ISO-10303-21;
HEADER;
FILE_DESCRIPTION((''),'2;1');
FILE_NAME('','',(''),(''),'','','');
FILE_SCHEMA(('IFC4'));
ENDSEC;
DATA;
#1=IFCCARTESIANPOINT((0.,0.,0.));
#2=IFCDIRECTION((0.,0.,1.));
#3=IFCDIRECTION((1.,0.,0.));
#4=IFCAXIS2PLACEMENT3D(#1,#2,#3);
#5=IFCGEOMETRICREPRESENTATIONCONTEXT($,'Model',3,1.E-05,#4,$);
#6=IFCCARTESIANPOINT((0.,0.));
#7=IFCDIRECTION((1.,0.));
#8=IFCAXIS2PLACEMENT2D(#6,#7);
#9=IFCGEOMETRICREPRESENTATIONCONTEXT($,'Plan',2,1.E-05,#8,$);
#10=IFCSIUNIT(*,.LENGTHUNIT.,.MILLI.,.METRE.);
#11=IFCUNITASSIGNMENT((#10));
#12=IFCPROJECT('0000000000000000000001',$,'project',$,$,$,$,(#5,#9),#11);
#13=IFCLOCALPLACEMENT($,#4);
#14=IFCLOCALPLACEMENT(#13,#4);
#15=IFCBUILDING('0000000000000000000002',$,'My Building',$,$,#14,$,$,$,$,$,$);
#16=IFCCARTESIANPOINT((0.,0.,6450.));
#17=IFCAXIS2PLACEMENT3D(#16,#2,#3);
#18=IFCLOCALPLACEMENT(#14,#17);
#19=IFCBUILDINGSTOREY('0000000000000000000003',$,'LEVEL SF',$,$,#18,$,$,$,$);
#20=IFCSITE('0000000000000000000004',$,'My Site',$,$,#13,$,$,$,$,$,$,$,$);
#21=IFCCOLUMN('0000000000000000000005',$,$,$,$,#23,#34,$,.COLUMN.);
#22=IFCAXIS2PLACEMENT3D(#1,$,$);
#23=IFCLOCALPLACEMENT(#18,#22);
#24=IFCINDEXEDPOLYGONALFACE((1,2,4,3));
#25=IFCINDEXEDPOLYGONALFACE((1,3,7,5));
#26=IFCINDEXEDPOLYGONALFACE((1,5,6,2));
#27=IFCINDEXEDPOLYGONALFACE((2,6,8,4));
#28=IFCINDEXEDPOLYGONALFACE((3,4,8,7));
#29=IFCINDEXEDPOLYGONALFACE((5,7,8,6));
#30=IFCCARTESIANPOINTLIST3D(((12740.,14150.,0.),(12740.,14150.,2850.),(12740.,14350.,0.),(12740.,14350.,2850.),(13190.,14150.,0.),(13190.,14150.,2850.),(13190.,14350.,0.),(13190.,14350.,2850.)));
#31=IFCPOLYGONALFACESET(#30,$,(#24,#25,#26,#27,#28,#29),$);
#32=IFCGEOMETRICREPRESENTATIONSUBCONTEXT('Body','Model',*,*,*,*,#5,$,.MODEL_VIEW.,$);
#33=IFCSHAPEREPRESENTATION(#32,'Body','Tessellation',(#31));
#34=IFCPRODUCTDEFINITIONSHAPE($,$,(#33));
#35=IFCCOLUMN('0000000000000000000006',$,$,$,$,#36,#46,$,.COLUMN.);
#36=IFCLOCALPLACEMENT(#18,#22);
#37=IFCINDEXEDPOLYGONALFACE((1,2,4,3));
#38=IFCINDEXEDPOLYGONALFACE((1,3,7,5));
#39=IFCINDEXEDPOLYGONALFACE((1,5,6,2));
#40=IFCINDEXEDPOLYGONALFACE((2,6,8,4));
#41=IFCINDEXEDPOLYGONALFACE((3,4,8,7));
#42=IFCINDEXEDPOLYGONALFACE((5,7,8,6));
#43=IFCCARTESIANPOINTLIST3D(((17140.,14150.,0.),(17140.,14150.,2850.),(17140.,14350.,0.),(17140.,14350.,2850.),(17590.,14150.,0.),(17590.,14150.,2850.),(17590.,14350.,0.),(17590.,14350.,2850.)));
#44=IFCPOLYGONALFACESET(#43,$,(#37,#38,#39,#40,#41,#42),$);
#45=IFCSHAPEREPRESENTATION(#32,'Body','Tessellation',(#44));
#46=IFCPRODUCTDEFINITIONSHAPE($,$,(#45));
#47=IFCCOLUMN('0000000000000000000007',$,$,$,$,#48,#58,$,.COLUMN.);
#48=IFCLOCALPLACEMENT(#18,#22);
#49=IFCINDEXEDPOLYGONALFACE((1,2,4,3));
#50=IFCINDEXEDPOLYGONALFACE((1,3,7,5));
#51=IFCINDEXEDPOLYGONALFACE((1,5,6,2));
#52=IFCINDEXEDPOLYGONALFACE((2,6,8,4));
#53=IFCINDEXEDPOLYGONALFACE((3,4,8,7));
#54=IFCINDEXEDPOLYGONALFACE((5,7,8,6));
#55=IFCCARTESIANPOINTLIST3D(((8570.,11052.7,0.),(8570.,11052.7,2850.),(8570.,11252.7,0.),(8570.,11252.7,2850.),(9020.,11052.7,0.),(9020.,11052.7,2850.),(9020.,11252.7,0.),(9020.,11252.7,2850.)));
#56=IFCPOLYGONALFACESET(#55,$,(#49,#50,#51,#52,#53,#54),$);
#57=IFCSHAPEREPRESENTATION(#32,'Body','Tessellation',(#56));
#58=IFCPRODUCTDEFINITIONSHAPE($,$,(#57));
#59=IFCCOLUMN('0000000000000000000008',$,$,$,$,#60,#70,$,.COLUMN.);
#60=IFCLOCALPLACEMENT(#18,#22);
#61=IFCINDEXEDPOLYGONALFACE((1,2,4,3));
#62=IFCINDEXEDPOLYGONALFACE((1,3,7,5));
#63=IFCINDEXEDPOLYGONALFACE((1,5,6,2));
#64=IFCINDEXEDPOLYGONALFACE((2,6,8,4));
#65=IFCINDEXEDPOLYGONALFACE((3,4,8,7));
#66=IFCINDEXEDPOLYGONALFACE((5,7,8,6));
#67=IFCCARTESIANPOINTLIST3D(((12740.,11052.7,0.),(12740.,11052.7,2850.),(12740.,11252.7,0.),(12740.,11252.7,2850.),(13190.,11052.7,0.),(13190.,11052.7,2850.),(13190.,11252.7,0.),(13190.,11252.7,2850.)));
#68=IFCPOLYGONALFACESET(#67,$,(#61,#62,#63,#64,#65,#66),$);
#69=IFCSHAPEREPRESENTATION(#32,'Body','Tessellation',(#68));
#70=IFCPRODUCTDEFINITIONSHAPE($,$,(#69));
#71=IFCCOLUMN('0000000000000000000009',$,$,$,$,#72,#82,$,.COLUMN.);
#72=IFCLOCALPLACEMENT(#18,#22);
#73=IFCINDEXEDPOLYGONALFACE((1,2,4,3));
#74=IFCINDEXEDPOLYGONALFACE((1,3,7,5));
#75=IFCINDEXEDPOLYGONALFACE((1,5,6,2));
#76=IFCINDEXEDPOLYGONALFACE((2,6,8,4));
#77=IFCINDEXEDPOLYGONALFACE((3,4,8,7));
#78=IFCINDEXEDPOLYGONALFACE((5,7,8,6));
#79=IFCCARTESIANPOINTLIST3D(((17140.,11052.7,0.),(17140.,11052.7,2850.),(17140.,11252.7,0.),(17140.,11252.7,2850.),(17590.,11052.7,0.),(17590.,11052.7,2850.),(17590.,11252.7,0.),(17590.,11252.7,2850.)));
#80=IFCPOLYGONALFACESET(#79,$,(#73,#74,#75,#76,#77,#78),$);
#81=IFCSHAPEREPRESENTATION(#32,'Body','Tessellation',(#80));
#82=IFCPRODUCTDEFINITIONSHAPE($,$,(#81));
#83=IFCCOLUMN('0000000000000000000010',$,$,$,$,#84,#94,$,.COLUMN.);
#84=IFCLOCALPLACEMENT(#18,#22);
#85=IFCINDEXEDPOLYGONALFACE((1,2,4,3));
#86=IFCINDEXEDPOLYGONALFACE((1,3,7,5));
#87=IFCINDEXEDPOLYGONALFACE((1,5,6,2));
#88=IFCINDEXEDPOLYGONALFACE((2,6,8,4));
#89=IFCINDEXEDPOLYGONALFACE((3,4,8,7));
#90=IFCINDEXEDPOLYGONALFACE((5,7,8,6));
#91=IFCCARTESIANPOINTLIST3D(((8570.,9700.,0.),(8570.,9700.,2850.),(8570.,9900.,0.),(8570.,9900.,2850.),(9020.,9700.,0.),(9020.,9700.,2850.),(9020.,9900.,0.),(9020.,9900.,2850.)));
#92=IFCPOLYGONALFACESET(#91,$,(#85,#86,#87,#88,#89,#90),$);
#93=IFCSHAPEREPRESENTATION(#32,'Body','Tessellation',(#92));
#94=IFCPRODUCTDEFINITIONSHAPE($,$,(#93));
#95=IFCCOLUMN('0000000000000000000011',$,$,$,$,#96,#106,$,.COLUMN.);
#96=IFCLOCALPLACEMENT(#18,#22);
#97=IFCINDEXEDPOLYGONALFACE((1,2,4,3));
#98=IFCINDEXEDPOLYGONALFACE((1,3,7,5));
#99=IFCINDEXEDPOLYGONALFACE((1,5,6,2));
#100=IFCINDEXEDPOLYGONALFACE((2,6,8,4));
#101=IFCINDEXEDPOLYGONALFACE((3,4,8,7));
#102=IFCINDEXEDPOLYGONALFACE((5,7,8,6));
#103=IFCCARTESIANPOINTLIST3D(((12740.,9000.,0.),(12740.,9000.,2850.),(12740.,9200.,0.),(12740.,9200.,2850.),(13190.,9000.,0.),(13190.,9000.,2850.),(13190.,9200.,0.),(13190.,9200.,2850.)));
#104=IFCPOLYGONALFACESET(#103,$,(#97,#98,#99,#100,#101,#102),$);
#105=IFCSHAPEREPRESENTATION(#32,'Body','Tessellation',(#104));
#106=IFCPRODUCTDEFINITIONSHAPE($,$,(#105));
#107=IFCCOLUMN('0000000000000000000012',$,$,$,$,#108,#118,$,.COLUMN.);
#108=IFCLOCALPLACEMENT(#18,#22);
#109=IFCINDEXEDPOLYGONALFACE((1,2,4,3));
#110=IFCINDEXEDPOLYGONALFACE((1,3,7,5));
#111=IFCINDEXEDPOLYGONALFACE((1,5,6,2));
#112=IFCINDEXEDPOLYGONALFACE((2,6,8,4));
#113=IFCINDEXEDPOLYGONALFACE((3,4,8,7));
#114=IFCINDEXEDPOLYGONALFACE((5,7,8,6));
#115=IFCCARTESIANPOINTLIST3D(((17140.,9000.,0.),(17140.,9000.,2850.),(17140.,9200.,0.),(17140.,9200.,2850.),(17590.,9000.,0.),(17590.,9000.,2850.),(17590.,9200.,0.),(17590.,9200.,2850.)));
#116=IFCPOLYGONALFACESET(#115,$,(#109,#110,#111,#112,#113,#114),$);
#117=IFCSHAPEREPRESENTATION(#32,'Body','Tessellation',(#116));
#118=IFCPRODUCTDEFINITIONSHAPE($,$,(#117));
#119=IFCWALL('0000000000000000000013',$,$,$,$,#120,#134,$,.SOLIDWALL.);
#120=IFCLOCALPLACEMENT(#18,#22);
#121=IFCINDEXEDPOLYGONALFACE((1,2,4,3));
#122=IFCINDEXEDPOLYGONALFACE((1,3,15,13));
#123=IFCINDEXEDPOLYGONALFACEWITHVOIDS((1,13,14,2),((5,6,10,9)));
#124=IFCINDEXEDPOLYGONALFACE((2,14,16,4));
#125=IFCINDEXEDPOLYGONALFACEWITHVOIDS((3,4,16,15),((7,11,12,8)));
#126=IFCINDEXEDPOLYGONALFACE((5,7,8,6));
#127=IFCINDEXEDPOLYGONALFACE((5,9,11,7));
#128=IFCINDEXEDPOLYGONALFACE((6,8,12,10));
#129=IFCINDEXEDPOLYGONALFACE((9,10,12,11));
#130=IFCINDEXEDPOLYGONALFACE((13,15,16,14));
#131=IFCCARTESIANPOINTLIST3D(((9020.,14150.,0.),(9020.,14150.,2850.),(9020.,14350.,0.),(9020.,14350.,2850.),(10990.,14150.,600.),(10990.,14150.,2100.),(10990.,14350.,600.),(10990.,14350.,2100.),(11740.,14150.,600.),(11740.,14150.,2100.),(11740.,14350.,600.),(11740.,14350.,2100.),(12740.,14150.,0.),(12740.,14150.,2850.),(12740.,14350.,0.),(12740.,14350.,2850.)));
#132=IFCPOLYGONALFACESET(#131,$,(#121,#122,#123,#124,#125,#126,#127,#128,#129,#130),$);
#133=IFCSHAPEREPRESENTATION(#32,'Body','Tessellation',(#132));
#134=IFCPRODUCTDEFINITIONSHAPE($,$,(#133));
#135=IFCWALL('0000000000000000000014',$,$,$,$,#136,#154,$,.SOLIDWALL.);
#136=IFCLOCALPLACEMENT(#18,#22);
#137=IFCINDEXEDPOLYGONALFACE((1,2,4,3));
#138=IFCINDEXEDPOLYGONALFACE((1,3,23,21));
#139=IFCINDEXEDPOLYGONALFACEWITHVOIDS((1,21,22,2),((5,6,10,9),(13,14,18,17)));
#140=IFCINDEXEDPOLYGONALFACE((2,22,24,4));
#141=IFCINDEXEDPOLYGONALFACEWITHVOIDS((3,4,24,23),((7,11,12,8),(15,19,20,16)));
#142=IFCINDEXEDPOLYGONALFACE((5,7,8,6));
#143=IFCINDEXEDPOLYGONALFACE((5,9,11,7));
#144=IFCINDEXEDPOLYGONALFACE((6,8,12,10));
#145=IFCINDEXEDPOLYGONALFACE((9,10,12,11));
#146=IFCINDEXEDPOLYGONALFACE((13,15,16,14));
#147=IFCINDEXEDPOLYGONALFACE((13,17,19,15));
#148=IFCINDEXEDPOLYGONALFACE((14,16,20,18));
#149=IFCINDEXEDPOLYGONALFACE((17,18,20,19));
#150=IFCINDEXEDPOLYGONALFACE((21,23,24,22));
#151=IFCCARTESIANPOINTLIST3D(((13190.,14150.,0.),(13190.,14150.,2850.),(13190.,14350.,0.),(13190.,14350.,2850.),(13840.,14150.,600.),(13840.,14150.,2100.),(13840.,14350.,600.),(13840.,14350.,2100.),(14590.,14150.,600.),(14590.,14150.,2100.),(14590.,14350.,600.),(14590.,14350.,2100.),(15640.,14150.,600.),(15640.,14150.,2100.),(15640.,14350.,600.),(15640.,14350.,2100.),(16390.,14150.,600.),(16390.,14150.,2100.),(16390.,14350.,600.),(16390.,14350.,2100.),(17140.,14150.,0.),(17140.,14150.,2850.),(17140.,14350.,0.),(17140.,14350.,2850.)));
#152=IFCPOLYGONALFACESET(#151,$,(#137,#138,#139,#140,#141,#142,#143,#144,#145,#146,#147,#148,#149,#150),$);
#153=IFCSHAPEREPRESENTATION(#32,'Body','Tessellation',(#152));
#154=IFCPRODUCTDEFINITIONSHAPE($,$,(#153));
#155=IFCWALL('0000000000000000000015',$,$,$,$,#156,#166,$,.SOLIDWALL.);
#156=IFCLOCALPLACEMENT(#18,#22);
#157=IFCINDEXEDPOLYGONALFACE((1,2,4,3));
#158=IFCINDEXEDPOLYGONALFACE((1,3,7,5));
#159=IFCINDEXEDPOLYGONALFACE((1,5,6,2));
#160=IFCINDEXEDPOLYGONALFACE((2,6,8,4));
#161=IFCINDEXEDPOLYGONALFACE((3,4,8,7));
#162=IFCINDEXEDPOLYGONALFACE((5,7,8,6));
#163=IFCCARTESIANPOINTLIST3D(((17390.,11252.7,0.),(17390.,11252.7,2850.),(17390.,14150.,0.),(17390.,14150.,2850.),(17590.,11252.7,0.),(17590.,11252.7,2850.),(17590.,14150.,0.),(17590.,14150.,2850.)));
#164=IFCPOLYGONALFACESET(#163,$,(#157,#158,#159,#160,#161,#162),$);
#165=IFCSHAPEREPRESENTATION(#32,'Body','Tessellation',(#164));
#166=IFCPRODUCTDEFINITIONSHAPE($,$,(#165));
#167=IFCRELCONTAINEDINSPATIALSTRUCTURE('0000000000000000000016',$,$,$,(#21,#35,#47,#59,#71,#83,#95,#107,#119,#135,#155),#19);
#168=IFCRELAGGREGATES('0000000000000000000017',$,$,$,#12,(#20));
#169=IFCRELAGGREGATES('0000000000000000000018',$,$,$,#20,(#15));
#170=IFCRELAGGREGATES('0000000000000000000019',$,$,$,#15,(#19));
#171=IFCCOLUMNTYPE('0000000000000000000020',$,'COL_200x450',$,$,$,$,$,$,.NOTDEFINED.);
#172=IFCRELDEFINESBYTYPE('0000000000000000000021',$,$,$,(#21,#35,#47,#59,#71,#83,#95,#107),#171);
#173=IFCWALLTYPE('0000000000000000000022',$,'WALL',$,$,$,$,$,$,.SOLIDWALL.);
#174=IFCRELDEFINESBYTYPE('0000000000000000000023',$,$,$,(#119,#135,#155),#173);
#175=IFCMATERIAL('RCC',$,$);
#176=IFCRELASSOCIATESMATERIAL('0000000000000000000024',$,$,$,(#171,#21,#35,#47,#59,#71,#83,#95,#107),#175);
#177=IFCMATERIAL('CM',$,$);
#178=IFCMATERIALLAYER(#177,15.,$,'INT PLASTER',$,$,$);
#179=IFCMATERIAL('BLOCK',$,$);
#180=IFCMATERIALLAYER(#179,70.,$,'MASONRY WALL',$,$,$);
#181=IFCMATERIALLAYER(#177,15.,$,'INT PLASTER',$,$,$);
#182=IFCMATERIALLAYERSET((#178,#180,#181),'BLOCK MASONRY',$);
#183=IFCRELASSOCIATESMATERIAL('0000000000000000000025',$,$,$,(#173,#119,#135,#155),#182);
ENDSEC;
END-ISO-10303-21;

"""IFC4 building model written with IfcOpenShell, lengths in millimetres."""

from ifc_helpers import new_model, si_unit, frame, origin_with_axes, origin_2d_with_axis, place, context, subcontext, project, spatial, indexed_curve, rectangle, outline, extrude, material, layer, layer_set, layer_usage, material_profile, profile_set, profile_usage, type_object, element, save


model = new_model("IFC4")

# Units and contexts
model_context = context("Model", 3, precision=1e-05, world=origin_with_axes())
plan_context = context("Plan", 2, precision=1e-05, world=origin_2d_with_axis())
body_context = subcontext(model_context, "Body", "Model", "MODEL_VIEW")
ifc_project = project(units=[si_unit("LENGTHUNIT", "METRE", prefix="MILLI")], contexts=[model_context, plan_context])

# Site, building, storey
site_placement = place(None, origin_with_axes())
site = spatial("IfcSite", under=ifc_project, at=site_placement, Name="My Site")
building_placement = place(site_placement, origin_with_axes())
building = spatial("IfcBuilding", under=site, at=building_placement, Name="My Building")
storey_placement = place(building_placement, frame((0.0, 0.0, 6450.0), z_axis=(0.0, 0.0, 1.0), x_axis=(1.0, 0.0, 0.0)))
storey = spatial("IfcBuildingStorey", under=building, at=storey_placement, Name="LEVEL SF")

# Columns
ifc_material_1 = material(Name="RCC")
ifc_material_profile = material_profile(ifc_material_1, rectangle(XDim=200.0, YDim=450.0))
ifc_profile_set = profile_set([ifc_material_profile], Name="COL_200x450")
ifc_profile_usage_1 = profile_usage(ifc_profile_set)
column_type = type_object("IfcColumnType", Name="COL_200x450", PredefinedType="NOTDEFINED", material=ifc_profile_set)
column_1_placement = place(storey_placement, frame((12965.0, 14250.0, 0.0), z_axis=(0.0, 0.0, 1.0), x_axis=(0.0, -1.0, 0.0)))
element("IfcColumn", 1, at=column_1_placement, inside=storey, type_object=column_type, material=ifc_profile_usage_1, PredefinedType="COLUMN", context=body_context, shape_type="SweptSolid", body=[
    extrude(rectangle(XDim=200.0, YDim=450.0), origin_with_axes(), (0.0, 0.0, 1.0), 2850.0),
])
ifc_profile_usage_2 = profile_usage(ifc_profile_set)
column_2_placement = place(storey_placement, frame((17365.0, 14250.0, 0.0), z_axis=(0.0, 0.0, 1.0), x_axis=(0.0, -1.0, 0.0)))
element("IfcColumn", 2, at=column_2_placement, inside=storey, type_object=column_type, material=ifc_profile_usage_2, PredefinedType="COLUMN", context=body_context, shape_type="SweptSolid", body=[
    extrude(rectangle(XDim=200.0, YDim=450.0), origin_with_axes(), (0.0, 0.0, 1.0), 2850.0),
])
ifc_profile_usage_3 = profile_usage(ifc_profile_set)
column_3_placement = place(storey_placement, frame((8795.0, 11152.7, 0.0), z_axis=(0.0, 0.0, 1.0), x_axis=(0.0, -1.0, 0.0)))
element("IfcColumn", 3, at=column_3_placement, inside=storey, type_object=column_type, material=ifc_profile_usage_3, PredefinedType="COLUMN", context=body_context, shape_type="SweptSolid", body=[
    extrude(rectangle(XDim=200.0, YDim=450.0), origin_with_axes(), (0.0, 0.0, 1.0), 2850.0),
])
ifc_profile_usage_4 = profile_usage(ifc_profile_set)
column_4_placement = place(storey_placement, frame((12965.0, 11152.7, 0.0), z_axis=(0.0, 0.0, 1.0), x_axis=(0.0, -1.0, 0.0)))
element("IfcColumn", 4, at=column_4_placement, inside=storey, type_object=column_type, material=ifc_profile_usage_4, PredefinedType="COLUMN", context=body_context, shape_type="SweptSolid", body=[
    extrude(rectangle(XDim=200.0, YDim=450.0), origin_with_axes(), (0.0, 0.0, 1.0), 2850.0),
])
ifc_profile_usage_5 = profile_usage(ifc_profile_set)
column_5_placement = place(storey_placement, frame((17365.0, 11152.7, 0.0), z_axis=(0.0, 0.0, 1.0), x_axis=(0.0, -1.0, 0.0)))
element("IfcColumn", 5, at=column_5_placement, inside=storey, type_object=column_type, material=ifc_profile_usage_5, PredefinedType="COLUMN", context=body_context, shape_type="SweptSolid", body=[
    extrude(rectangle(XDim=200.0, YDim=450.0), origin_with_axes(), (0.0, 0.0, 1.0), 2850.0),
])
ifc_profile_usage_6 = profile_usage(ifc_profile_set)
column_6_placement = place(storey_placement, frame((8795.0, 9800.0, 0.0), z_axis=(0.0, 0.0, 1.0), x_axis=(0.0, -1.0, 0.0)))
element("IfcColumn", 6, at=column_6_placement, inside=storey, type_object=column_type, material=ifc_profile_usage_6, PredefinedType="COLUMN", context=body_context, shape_type="SweptSolid", body=[
    extrude(rectangle(XDim=200.0, YDim=450.0), origin_with_axes(), (0.0, 0.0, 1.0), 2850.0),
])
ifc_profile_usage_7 = profile_usage(ifc_profile_set)
column_7_placement = place(storey_placement, frame((12965.0, 9100.0, 0.0), z_axis=(0.0, 0.0, 1.0), x_axis=(0.0, -1.0, 0.0)))
element("IfcColumn", 7, at=column_7_placement, inside=storey, type_object=column_type, material=ifc_profile_usage_7, PredefinedType="COLUMN", context=body_context, shape_type="SweptSolid", body=[
    extrude(rectangle(XDim=200.0, YDim=450.0), origin_with_axes(), (0.0, 0.0, 1.0), 2850.0),
])
ifc_profile_usage_8 = profile_usage(ifc_profile_set)
column_8_placement = place(storey_placement, frame((17365.0, 9100.0, 0.0), z_axis=(0.0, 0.0, 1.0), x_axis=(0.0, -1.0, 0.0)))
element("IfcColumn", 8, at=column_8_placement, inside=storey, type_object=column_type, material=ifc_profile_usage_8, PredefinedType="COLUMN", context=body_context, shape_type="SweptSolid", body=[
    extrude(rectangle(XDim=200.0, YDim=450.0), origin_with_axes(), (0.0, 0.0, 1.0), 2850.0),
])

# Wall, opening
ifc_material_2 = material(Name="CM")
ifc_layer_1 = layer(ifc_material_2, 15.0, Name="INT PLASTER")
ifc_material_3 = material(Name="BLOCK")
ifc_layer_2 = layer(ifc_material_3, 70.0, Name="MASONRY WALL")
ifc_layer_3 = layer(ifc_material_2, 15.0, Name="INT PLASTER")
ifc_layer_set = layer_set([ifc_layer_1, ifc_layer_2, ifc_layer_3], Name="BLOCK MASONRY")
ifc_layer_usage_1 = layer_usage(ifc_layer_set, "AXIS2", "POSITIVE", 0.0)
wall_type = type_object("IfcWallType", Name="WALL", PredefinedType="SOLIDWALL", material=ifc_layer_set)
wall_1_placement = place(storey_placement, frame((9020.0, 14350.0, 0.0), z_axis=(0.0, 0.0, 1.0), x_axis=(0.0, -1.0, 0.0)))
wall_1 = element("IfcWall", 9, at=wall_1_placement, inside=storey, type_object=wall_type, material=ifc_layer_usage_1, PredefinedType="SOLIDWALL", context=body_context, shape_type="SweptSolid", body=[
    extrude(outline(indexed_curve([(0.0, 0.0), (0.0, 3720.0), (200.0, 3720.0), (200.0, 0.0), (0.0, 0.0)], self_intersect=False)), origin_with_axes(), (0.0, 0.0, 1.0), 2850.0),
])
opening_1_placement = place(wall_1_placement, frame((200.0, 1970.0, 600.0), z_axis=(0.0, 0.0, 1.0), x_axis=(0.0, 1.0, 0.0)))
element("IfcOpeningElement", 10, at=opening_1_placement, cuts=wall_1, PredefinedType="OPENING", context=body_context, shape_type="SweptSolid", body=[
    extrude(outline(indexed_curve([(0.0, 0.0), (0.0, 400.0), (750.0, 400.0), (750.0, 0.0), (0.0, 0.0)], self_intersect=False)), frame((0.0, -100.0, 0.0), z_axis=(0.0, 0.0, 1.0), x_axis=(1.0, 0.0, 0.0)), (0.0, 0.0, 1.0), 1500.0),
])

# Wall, openings
ifc_layer_usage_2 = layer_usage(ifc_layer_set, "AXIS2", "POSITIVE", 0.0)
wall_2_placement = place(storey_placement, frame((13190.0, 14350.0, 0.0), z_axis=(0.0, 0.0, 1.0), x_axis=(0.0, -1.0, 0.0)))
wall_2 = element("IfcWall", 11, at=wall_2_placement, inside=storey, type_object=wall_type, material=ifc_layer_usage_2, PredefinedType="SOLIDWALL", context=body_context, shape_type="SweptSolid", body=[
    extrude(outline(indexed_curve([(0.0, 0.0), (0.0, 3950.0), (200.0, 3950.0), (200.0, 0.0), (0.0, 0.0)], self_intersect=False)), origin_with_axes(), (0.0, 0.0, 1.0), 2850.0),
])
opening_2_placement = place(wall_2_placement, frame((200.0, 650.0, 600.0), z_axis=(0.0, 0.0, 1.0), x_axis=(0.0, 1.0, 0.0)))
element("IfcOpeningElement", 12, at=opening_2_placement, cuts=wall_2, PredefinedType="OPENING", context=body_context, shape_type="SweptSolid", body=[
    extrude(outline(indexed_curve([(0.0, 0.0), (0.0, 400.0), (750.0, 400.0), (750.0, 0.0), (0.0, 0.0)], self_intersect=False)), frame((0.0, -100.0, 0.0), z_axis=(0.0, 0.0, 1.0), x_axis=(1.0, 0.0, 0.0)), (0.0, 0.0, 1.0), 1500.0),
])
opening_3_placement = place(wall_2_placement, frame((200.0, 2450.0, 600.0), z_axis=(0.0, 0.0, 1.0), x_axis=(0.0, 1.0, 0.0)))
element("IfcOpeningElement", 13, at=opening_3_placement, cuts=wall_2, PredefinedType="OPENING", context=body_context, shape_type="SweptSolid", body=[
    extrude(outline(indexed_curve([(0.0, 0.0), (0.0, 400.0), (750.0, 400.0), (750.0, 0.0), (0.0, 0.0)], self_intersect=False)), frame((0.0, -100.0, 0.0), z_axis=(0.0, 0.0, 1.0), x_axis=(1.0, 0.0, 0.0)), (0.0, 0.0, 1.0), 1500.0),
])

# Wall
ifc_layer_usage_3 = layer_usage(ifc_layer_set, "AXIS2", "POSITIVE", 0.0)
wall_3_placement = place(storey_placement, frame((17590.0, 11252.7, 0.0), z_axis=(0.0, 0.0, 1.0), x_axis=(0.0, 1.0, 0.0)))
element("IfcWall", 14, at=wall_3_placement, inside=storey, type_object=wall_type, material=ifc_layer_usage_3, PredefinedType="SOLIDWALL", context=body_context, shape_type="SweptSolid", body=[
    extrude(outline(indexed_curve([(0.0, 0.0), (0.0, 200.0), (2897.3, 200.0), (2897.3, 0.0), (0.0, 0.0)], self_intersect=False)), origin_with_axes(), (0.0, 0.0, 1.0), 2850.0),
])

save(model, "model.ifc")
